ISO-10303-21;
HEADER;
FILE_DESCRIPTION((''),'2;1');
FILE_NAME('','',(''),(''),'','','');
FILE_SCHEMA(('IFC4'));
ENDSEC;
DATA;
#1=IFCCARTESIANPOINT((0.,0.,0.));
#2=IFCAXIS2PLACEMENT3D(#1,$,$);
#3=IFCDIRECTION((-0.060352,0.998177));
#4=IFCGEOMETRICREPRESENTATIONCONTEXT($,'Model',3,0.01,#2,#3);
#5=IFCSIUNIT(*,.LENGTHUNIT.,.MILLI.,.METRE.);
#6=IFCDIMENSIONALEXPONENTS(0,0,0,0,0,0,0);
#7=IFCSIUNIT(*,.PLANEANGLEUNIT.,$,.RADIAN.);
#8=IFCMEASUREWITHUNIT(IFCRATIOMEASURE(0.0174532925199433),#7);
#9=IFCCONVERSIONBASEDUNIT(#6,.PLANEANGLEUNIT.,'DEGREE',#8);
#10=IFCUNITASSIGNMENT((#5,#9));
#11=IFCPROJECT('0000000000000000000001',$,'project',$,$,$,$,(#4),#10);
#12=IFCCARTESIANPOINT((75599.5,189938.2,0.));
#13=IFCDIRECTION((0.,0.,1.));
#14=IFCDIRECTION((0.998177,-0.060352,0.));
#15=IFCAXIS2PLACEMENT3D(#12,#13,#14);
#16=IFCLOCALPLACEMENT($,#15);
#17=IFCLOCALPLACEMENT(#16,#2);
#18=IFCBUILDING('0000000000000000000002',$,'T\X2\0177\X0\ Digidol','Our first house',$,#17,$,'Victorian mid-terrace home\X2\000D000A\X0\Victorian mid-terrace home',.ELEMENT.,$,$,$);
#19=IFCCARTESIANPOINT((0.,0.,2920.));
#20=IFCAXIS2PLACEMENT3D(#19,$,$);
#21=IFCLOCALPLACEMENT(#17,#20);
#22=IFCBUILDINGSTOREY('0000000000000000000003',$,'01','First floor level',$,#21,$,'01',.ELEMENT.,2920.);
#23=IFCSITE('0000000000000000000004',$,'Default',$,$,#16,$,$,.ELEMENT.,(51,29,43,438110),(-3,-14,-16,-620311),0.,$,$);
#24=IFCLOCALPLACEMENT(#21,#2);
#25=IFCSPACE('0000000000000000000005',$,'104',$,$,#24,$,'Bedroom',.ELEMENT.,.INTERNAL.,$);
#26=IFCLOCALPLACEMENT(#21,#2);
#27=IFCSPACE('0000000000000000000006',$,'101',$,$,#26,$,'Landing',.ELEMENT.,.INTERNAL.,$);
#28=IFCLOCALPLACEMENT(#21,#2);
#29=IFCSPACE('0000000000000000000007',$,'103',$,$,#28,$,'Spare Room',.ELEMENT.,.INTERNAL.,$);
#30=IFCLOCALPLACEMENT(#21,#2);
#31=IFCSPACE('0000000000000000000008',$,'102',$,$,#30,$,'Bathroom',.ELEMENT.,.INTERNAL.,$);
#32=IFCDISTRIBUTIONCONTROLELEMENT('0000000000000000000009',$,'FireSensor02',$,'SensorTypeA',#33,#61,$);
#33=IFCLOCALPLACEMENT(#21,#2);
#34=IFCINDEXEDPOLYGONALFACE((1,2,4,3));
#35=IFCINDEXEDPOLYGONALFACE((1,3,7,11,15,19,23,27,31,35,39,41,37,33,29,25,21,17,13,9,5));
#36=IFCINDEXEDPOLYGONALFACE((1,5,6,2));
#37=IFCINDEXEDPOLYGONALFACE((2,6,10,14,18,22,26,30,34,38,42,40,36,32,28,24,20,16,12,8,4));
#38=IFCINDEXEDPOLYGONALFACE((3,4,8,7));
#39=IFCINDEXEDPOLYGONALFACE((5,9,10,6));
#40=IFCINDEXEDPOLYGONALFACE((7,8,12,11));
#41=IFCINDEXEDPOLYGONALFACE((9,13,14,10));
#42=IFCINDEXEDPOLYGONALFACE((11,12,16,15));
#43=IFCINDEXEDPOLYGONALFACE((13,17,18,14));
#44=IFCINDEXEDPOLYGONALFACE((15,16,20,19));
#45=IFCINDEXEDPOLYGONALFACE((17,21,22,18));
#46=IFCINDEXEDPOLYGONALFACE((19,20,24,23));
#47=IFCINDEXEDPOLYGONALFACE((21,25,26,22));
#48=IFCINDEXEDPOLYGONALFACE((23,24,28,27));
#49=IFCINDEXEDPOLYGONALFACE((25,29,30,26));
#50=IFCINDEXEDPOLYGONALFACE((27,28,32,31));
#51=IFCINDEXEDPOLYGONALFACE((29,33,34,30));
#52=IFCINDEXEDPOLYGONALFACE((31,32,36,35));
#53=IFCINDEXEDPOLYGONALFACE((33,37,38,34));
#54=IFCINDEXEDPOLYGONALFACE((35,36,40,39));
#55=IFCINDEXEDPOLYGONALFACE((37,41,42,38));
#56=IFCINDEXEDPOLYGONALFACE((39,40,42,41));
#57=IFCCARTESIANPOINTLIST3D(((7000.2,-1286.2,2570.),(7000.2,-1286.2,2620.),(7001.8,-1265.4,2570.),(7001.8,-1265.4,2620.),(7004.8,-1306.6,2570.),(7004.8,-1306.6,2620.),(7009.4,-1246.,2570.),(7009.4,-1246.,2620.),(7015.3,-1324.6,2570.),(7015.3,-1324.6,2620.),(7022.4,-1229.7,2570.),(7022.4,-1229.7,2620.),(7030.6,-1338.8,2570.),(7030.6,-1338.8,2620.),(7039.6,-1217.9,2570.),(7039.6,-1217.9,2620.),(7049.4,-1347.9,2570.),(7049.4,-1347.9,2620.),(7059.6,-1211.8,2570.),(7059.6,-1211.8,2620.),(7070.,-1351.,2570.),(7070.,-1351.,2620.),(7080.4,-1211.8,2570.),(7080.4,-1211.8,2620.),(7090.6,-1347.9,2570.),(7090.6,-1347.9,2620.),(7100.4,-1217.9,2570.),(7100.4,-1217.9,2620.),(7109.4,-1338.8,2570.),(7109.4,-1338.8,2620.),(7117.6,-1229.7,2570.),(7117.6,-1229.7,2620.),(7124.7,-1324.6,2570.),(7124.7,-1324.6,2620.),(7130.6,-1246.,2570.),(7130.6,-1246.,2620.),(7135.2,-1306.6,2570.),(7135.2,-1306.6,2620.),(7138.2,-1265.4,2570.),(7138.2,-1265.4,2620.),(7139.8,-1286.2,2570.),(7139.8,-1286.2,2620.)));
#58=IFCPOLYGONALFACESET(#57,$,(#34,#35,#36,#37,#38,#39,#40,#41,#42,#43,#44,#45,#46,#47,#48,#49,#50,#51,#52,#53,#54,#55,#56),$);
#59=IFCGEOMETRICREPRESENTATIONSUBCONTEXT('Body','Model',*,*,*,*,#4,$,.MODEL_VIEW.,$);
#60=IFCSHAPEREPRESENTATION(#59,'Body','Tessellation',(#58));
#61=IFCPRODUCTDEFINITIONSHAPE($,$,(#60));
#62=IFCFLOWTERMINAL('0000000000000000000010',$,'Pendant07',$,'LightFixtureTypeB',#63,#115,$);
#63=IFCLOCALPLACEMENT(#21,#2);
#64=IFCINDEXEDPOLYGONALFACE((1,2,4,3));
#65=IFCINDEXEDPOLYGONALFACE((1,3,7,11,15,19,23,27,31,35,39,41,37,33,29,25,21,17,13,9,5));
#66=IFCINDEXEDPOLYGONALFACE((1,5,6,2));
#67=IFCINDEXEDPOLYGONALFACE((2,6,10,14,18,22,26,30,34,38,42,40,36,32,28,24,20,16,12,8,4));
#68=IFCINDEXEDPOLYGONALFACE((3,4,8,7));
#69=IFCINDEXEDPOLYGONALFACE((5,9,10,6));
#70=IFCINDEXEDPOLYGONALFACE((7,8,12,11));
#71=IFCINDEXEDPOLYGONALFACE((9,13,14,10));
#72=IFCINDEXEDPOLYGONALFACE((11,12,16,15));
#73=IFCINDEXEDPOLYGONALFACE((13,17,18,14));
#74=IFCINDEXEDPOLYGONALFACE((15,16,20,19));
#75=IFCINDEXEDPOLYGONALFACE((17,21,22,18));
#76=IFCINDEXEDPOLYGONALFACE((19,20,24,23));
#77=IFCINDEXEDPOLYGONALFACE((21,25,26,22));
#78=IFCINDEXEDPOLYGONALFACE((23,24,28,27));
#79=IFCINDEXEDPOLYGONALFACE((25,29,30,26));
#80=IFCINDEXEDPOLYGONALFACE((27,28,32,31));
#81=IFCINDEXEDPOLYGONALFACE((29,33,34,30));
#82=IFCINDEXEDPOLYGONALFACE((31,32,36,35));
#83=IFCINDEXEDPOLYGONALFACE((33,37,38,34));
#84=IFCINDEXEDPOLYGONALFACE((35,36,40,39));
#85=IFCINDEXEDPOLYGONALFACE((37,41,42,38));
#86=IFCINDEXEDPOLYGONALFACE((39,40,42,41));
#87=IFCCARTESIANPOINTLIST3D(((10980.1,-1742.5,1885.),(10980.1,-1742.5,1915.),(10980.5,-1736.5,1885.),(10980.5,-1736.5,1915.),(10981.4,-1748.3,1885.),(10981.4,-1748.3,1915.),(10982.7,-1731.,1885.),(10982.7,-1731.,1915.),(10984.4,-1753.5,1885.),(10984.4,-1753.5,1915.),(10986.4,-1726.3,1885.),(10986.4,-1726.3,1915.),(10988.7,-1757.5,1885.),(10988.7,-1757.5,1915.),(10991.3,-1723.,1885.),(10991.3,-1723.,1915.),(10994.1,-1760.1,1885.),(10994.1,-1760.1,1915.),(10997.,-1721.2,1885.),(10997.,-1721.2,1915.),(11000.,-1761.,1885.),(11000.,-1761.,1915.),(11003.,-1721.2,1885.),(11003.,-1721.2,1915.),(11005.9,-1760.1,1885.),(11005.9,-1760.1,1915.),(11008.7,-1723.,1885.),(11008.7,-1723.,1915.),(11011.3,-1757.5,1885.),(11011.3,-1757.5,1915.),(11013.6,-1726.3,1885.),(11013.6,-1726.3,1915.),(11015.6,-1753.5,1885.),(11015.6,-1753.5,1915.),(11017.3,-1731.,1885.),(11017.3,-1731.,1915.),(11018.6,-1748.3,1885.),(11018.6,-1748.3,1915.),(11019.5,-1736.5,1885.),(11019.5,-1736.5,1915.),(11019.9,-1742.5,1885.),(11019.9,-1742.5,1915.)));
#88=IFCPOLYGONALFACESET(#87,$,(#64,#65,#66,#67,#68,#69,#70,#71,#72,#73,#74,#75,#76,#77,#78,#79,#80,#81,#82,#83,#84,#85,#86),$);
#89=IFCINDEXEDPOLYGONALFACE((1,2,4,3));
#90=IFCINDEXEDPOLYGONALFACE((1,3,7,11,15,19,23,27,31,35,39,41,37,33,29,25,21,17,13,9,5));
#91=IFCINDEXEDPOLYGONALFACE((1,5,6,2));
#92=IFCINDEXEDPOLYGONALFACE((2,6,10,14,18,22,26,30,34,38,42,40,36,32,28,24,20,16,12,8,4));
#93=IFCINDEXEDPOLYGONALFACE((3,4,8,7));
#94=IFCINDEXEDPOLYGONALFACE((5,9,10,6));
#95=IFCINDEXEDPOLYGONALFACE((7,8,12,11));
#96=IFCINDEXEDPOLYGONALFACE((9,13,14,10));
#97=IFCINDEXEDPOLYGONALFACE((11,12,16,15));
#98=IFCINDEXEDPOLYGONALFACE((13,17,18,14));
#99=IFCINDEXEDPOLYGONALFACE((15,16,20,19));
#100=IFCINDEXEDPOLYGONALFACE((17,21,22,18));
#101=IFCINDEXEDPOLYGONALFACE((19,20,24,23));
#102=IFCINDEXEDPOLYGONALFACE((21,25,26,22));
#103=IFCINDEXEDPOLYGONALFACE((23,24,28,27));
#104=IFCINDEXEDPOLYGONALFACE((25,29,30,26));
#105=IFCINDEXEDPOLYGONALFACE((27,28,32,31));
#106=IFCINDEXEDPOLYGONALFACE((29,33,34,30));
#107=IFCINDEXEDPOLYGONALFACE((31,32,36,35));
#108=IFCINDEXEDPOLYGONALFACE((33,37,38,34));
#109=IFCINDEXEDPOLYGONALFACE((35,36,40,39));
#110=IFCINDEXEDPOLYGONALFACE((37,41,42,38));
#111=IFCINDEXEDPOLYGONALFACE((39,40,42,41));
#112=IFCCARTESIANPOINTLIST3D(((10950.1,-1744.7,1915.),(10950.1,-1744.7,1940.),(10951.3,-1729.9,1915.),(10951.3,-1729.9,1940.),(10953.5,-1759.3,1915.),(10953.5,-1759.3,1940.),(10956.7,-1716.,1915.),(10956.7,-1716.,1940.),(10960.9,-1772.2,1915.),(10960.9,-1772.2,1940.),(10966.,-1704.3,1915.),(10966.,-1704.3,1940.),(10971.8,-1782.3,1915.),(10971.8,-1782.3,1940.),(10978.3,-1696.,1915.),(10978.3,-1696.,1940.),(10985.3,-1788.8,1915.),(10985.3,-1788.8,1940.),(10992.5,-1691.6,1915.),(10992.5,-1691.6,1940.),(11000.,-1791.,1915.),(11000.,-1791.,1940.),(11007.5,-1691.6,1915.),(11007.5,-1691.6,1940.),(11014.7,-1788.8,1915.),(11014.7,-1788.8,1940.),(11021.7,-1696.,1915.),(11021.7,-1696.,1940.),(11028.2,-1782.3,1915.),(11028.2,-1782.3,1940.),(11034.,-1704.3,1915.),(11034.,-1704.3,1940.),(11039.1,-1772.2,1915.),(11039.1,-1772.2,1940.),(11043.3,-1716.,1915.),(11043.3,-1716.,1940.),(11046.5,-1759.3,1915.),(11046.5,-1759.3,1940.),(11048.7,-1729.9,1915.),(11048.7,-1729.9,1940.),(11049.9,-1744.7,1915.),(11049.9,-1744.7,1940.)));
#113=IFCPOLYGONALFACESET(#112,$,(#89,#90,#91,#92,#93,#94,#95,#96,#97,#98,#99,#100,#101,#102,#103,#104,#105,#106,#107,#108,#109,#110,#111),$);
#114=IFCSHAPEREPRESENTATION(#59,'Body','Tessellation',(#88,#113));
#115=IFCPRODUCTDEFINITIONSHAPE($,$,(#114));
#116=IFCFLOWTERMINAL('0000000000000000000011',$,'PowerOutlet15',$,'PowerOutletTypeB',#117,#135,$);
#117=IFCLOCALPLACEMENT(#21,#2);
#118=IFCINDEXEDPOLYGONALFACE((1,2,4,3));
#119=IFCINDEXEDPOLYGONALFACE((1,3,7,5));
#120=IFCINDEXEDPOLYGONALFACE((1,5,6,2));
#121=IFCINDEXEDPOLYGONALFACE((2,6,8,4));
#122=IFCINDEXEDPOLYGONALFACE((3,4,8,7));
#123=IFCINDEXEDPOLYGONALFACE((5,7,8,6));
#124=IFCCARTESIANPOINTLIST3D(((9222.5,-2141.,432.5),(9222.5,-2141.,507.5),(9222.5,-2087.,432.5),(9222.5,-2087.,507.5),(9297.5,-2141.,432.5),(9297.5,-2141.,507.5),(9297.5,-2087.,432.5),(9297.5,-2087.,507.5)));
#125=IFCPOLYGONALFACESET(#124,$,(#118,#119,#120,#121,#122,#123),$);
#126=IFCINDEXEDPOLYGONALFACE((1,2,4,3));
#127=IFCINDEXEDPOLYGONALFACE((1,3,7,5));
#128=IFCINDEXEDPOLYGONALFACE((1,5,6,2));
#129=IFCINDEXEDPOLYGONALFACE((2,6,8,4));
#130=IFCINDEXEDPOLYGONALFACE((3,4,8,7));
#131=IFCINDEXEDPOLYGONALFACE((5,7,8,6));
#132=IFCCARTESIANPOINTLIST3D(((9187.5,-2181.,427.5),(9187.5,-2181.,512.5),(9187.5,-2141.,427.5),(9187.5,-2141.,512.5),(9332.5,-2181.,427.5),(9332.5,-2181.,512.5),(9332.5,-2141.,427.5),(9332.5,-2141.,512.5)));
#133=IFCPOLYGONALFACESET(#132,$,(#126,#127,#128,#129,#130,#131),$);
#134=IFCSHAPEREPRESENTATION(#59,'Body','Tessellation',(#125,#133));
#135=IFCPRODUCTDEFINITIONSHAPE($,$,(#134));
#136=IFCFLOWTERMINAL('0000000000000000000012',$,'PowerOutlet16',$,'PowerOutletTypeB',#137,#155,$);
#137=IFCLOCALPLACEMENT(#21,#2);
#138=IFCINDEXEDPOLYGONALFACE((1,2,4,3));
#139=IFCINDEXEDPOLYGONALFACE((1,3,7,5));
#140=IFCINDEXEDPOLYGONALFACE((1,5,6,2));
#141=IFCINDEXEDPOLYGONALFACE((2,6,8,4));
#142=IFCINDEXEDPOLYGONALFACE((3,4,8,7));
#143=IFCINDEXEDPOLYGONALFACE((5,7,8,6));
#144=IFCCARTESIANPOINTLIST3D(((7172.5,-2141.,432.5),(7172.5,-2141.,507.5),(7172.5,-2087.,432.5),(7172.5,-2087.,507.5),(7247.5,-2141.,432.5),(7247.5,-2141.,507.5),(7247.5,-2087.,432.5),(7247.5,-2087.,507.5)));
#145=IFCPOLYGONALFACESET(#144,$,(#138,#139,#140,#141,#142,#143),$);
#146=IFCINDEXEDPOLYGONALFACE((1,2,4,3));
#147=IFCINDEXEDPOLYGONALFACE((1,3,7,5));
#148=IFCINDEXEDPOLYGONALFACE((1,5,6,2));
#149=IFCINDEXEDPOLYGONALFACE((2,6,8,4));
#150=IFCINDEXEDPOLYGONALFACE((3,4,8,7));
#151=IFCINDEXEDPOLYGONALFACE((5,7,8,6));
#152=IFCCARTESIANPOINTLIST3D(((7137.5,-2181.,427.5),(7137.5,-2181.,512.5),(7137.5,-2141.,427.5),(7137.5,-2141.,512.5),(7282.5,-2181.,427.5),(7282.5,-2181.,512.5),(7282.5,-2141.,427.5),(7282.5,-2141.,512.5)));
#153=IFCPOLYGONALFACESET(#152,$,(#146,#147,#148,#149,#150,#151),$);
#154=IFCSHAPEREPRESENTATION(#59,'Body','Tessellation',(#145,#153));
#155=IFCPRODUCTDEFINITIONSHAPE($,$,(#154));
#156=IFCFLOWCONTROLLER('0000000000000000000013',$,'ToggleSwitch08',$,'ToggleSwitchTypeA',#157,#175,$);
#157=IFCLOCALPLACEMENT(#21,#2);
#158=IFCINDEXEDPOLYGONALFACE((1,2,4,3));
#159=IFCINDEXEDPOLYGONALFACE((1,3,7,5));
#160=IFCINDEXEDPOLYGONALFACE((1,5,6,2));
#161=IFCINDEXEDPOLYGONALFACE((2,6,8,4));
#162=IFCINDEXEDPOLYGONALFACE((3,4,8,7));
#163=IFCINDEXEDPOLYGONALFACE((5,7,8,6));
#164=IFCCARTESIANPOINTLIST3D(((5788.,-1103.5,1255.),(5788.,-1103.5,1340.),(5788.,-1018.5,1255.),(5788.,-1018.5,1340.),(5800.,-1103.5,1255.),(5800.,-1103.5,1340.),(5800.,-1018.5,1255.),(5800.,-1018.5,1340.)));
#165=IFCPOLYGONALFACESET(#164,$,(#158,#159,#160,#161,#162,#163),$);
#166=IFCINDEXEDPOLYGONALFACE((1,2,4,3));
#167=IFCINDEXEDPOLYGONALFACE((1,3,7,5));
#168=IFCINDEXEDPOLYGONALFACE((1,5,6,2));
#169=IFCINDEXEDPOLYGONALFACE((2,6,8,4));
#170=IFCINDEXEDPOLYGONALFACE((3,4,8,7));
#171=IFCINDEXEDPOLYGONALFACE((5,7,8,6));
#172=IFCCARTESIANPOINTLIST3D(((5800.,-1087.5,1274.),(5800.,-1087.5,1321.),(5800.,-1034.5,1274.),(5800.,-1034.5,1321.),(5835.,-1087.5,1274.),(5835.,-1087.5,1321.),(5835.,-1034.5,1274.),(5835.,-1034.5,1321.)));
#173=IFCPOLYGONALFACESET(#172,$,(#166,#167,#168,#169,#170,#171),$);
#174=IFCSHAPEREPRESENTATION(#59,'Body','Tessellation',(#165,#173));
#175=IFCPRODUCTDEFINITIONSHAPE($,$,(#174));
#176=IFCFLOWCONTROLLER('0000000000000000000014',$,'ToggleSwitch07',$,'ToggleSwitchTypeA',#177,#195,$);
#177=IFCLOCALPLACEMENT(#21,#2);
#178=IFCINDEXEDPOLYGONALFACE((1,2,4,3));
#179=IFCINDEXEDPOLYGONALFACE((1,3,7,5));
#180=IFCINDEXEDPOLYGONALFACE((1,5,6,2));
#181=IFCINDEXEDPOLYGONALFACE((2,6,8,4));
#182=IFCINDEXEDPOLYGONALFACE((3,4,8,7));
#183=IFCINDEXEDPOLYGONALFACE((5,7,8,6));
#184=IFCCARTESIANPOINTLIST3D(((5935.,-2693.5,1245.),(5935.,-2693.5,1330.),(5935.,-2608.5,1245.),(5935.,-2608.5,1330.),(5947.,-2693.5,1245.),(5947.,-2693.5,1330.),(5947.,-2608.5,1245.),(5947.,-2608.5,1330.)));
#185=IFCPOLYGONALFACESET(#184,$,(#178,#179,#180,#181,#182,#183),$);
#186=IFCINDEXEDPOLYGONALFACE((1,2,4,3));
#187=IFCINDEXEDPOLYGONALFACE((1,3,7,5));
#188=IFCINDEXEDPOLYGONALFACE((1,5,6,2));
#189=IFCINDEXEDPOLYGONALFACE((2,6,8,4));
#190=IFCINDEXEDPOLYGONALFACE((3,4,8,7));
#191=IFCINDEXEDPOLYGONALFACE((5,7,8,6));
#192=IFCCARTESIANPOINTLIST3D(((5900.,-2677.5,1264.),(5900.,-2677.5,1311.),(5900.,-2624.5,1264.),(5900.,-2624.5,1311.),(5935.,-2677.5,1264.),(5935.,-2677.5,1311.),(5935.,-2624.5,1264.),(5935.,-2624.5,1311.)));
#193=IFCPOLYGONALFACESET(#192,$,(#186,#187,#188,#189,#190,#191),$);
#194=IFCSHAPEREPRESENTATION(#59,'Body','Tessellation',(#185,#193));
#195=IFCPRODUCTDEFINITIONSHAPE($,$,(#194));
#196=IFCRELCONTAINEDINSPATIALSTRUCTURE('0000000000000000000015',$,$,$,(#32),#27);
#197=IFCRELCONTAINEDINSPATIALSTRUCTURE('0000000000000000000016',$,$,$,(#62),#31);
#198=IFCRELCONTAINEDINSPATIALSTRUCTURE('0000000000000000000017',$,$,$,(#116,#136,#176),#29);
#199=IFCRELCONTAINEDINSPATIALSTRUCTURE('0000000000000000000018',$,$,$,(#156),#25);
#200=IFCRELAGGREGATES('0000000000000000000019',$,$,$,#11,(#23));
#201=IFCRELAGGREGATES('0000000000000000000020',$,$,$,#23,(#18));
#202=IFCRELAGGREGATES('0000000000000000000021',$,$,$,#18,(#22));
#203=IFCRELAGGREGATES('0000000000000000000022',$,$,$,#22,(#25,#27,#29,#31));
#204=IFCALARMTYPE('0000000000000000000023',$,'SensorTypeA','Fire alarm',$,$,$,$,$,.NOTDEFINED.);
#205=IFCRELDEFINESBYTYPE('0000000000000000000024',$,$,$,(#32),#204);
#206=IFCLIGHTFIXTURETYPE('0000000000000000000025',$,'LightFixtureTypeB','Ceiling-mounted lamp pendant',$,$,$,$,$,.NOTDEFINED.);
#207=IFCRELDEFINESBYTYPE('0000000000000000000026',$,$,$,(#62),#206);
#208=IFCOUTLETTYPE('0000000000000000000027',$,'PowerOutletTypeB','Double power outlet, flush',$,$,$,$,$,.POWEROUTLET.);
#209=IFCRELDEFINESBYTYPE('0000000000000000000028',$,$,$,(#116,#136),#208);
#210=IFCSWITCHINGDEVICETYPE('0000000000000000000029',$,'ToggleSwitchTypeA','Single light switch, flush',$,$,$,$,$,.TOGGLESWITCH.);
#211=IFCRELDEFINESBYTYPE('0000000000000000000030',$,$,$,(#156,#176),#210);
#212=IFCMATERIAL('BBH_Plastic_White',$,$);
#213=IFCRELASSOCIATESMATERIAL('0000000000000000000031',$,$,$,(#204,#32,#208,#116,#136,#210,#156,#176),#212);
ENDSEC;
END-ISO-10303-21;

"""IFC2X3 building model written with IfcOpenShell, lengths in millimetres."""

from ifc_helpers import new_model, entity, si_unit, converted_unit, direction, frame, frame_2d, origin, origin_2d_with_axis, place, context, subcontext, project, spatial, rectangle, circle, extrude, source, transform, mapped, material, type_object, type_shapes, element, save


model = new_model("IFC2X3")

# Units and contexts
model_context = context("Model", 3, precision=0.01, world=origin(), true_north=direction((-0.060352, 0.998177)))
body_context = subcontext(model_context, "Body", "Model", "MODEL_VIEW")
ifc_project = project(units=[si_unit("LENGTHUNIT", "METRE", prefix="MILLI"), converted_unit("PLANEANGLEUNIT", "DEGREE", entity("IfcRatioMeasure", 0.0174532925199433), si_unit("PLANEANGLEUNIT", "RADIAN"), dimensions=[0, 0, 0, 0, 0, 0, 0])], contexts=[model_context])

# Site, building, storey, space
site_placement = place(None, frame((75599.5, 189938.2, 0.0), z_axis=(0.0, 0.0, 1.0), x_axis=(0.998177, -0.060352, 0.0)))
site = spatial("IfcSite", under=ifc_project, at=site_placement, Name="Default", CompositionType="ELEMENT", RefLatitude=(51, 29, 43, 438110), RefLongitude=(-3, -14, -16, -620311), RefElevation=0.0)
building_placement = place(site_placement, origin())
building = spatial("IfcBuilding", under=site, at=building_placement, Name="Tŷ Digidol", Description="Our first house", LongName="Victorian mid-terrace home\r\nVictorian mid-terrace home", CompositionType="ELEMENT")
storey_placement = place(building_placement, frame((0.0, 0.0, 2920.0)))
storey = spatial("IfcBuildingStorey", under=building, at=storey_placement, Name="01", Description="First floor level", LongName="01", CompositionType="ELEMENT", Elevation=2920.0)
space_1_placement = place(storey_placement, origin())
space_1 = spatial("IfcSpace", under=storey, at=space_1_placement, Name="104", LongName="Bedroom", CompositionType="ELEMENT", InteriorOrExteriorSpace="INTERNAL")

# Shared definitions
ifc_material = material(Name="BBH_Plastic_White")

# Shared definitions
space_2_placement = place(storey_placement, origin())
space_2 = spatial("IfcSpace", under=storey, at=space_2_placement, Name="101", LongName="Landing", CompositionType="ELEMENT", InteriorOrExteriorSpace="INTERNAL")

# Shared definitions
space_3_placement = place(storey_placement, origin())
space_3 = spatial("IfcSpace", under=storey, at=space_3_placement, Name="103", LongName="Spare Room", CompositionType="ELEMENT", InteriorOrExteriorSpace="INTERNAL")

# Distribution control element
alarm_type = type_object("IfcAlarmType", Name="SensorTypeA", Description="Fire alarm", PredefinedType="NOTDEFINED", material=ifc_material)
shared_shape_1 = source(origin(), body_context, "Body", "SweptSolid", [
    extrude(circle(Radius=70.0, at=frame_2d((0.0, 0.0), x_axis=(1.0, 0.0))), origin(), (0.0, 0.0, 1.0), 50.0),
])
type_shapes(alarm_type, [shared_shape_1])
distribution_control_element_placement = place(space_2_placement, frame((7070.0, -1281.0, 2620.0), z_axis=(0.0, 0.0, -1.0), x_axis=(0.0, -1.0, 0.0)))
element("IfcDistributionControlElement", 1, at=distribution_control_element_placement, inside=space_2, type_object=alarm_type, material=ifc_material, Name="FireSensor02", ObjectType="SensorTypeA", context=body_context, shape_type="MappedRepresentation", body=[
    mapped(shared_shape_1, transform((0.0, 0.0, 0.0), scale=1.0)),
])

# Shared definitions
space_4_placement = place(storey_placement, origin())
space_4 = spatial("IfcSpace", under=storey, at=space_4_placement, Name="102", LongName="Bathroom", CompositionType="ELEMENT", InteriorOrExteriorSpace="INTERNAL")

# Flow terminals
light_fixture_type_1 = type_object("IfcLightFixtureType", Name="LightFixtureTypeB", Description="Ceiling-mounted lamp pendant", PredefinedType="NOTDEFINED")
shared_shape_2 = source(origin(), body_context, "Body", "SweptSolid", [
    extrude(circle(Radius=20.0, at=frame_2d((0.0, 0.0), x_axis=(1.0, 0.0))), frame((0.0, 0.0, 25.0)), (0.0, 0.0, 1.0), 30.0),
    extrude(circle(Radius=50.0, at=frame_2d((0.0, 0.0), x_axis=(1.0, 0.0))), origin(), (0.0, 0.0, 1.0), 25.0),
])
type_shapes(light_fixture_type_1, [shared_shape_2])
flow_terminal_1_placement = place(space_4_placement, frame((11000.0, -1741.0, 1940.0), z_axis=(0.0, 0.0, -1.0), x_axis=(0.0, -1.0, 0.0)))
element("IfcFlowTerminal", 2, at=flow_terminal_1_placement, inside=space_4, type_object=light_fixture_type_1, Name="Pendant07", ObjectType="LightFixtureTypeB", context=body_context, shape_type="MappedRepresentation", body=[
    mapped(shared_shape_2, transform((0.0, 0.0, 0.0), scale=1.0)),
])
outlet_type_1 = type_object("IfcOutletType", Name="PowerOutletTypeB", Description="Double power outlet, flush", PredefinedType="POWEROUTLET", material=ifc_material)
shared_shape_3 = source(origin(), body_context, "Body", "SweptSolid", [
    extrude(rectangle(XDim=75.0, YDim=75.0, at=origin_2d_with_axis()), frame((0.0, 0.0, -54.0), z_axis=(0.0, 0.0, 1.0), x_axis=(-1.0, 0.0, 0.0)), (0.0, 0.0, 1.0), 54.0),
    extrude(rectangle(XDim=145.0, YDim=85.0, at=origin_2d_with_axis()), frame((0.0, 0.0, 0.0), z_axis=(0.0, 0.0, 1.0), x_axis=(-1.0, 0.0, 0.0)), (0.0, 0.0, 1.0), 40.0),
])
type_shapes(outlet_type_1, [shared_shape_3])
for number, where, z_axis, x_axis, name in (
    (3, (9260.0, -2141.0, 470.0), (0.0, -1.0, 0.0), (-1.0, 0.0, 0.0), "PowerOutlet15"),
    (4, (7210.0, -2141.0, 470.0), (0.0, -1.0, 0.0), (-1.0, 0.0, 0.0), "PowerOutlet16"),
):
    element("IfcFlowTerminal", number, at=place(space_3_placement, frame(where, z_axis=z_axis, x_axis=x_axis)), inside=space_3, type_object=outlet_type_1, material=ifc_material, Name=name, ObjectType="PowerOutletTypeB", context=body_context, shape_type="MappedRepresentation", body=[
        mapped(shared_shape_3, transform((0.0, 0.0, 0.0), scale=1.0)),
    ])

# Flow controllers
switching_device_type_1 = type_object("IfcSwitchingDeviceType", Name="ToggleSwitchTypeA", Description="Single light switch, flush", PredefinedType="TOGGLESWITCH", material=ifc_material)
shared_shape_4 = source(origin(), body_context, "Body", "SweptSolid", [
    extrude(rectangle(XDim=85.0, YDim=85.0, at=origin_2d_with_axis()), frame((0.0, -42.5, 0.0), z_axis=(0.0, 0.0, 1.0), x_axis=(0.0, 1.0, 0.0)), (0.0, 0.0, 1.0), 12.0),
    extrude(rectangle(XDim=47.0, YDim=53.0, at=origin_2d_with_axis()), frame((0.0, -42.5, -35.0), z_axis=(0.0, 0.0, 1.0), x_axis=(0.0, 1.0, 0.0)), (0.0, 0.0, 1.0), 35.0),
])
type_shapes(switching_device_type_1, [shared_shape_4])
flow_controller_1_placement = place(space_1_placement, frame((5800.0, -1061.0, 1340.0), z_axis=(-1.0, 0.0, 0.0), x_axis=(0.0, -1.0, 0.0)))
element("IfcFlowController", 5, at=flow_controller_1_placement, inside=space_1, type_object=switching_device_type_1, material=ifc_material, Name="ToggleSwitch08", ObjectType="ToggleSwitchTypeA", context=body_context, shape_type="MappedRepresentation", body=[
    mapped(shared_shape_4, transform((0.0, 0.0, 0.0), scale=1.0)),
])
flow_controller_2_placement = place(space_3_placement, frame((5935.0, -2651.0, 1330.0), z_axis=(1.0, 0.0, 0.0), x_axis=(0.0, 1.0, 0.0)))
element("IfcFlowController", 6, at=flow_controller_2_placement, inside=space_3, type_object=switching_device_type_1, material=ifc_material, Name="ToggleSwitch07", ObjectType="ToggleSwitchTypeA", context=body_context, shape_type="MappedRepresentation", body=[
    mapped(shared_shape_4, transform((0.0, 0.0, 0.0), scale=1.0)),
])

save(model, "model.ifc")
